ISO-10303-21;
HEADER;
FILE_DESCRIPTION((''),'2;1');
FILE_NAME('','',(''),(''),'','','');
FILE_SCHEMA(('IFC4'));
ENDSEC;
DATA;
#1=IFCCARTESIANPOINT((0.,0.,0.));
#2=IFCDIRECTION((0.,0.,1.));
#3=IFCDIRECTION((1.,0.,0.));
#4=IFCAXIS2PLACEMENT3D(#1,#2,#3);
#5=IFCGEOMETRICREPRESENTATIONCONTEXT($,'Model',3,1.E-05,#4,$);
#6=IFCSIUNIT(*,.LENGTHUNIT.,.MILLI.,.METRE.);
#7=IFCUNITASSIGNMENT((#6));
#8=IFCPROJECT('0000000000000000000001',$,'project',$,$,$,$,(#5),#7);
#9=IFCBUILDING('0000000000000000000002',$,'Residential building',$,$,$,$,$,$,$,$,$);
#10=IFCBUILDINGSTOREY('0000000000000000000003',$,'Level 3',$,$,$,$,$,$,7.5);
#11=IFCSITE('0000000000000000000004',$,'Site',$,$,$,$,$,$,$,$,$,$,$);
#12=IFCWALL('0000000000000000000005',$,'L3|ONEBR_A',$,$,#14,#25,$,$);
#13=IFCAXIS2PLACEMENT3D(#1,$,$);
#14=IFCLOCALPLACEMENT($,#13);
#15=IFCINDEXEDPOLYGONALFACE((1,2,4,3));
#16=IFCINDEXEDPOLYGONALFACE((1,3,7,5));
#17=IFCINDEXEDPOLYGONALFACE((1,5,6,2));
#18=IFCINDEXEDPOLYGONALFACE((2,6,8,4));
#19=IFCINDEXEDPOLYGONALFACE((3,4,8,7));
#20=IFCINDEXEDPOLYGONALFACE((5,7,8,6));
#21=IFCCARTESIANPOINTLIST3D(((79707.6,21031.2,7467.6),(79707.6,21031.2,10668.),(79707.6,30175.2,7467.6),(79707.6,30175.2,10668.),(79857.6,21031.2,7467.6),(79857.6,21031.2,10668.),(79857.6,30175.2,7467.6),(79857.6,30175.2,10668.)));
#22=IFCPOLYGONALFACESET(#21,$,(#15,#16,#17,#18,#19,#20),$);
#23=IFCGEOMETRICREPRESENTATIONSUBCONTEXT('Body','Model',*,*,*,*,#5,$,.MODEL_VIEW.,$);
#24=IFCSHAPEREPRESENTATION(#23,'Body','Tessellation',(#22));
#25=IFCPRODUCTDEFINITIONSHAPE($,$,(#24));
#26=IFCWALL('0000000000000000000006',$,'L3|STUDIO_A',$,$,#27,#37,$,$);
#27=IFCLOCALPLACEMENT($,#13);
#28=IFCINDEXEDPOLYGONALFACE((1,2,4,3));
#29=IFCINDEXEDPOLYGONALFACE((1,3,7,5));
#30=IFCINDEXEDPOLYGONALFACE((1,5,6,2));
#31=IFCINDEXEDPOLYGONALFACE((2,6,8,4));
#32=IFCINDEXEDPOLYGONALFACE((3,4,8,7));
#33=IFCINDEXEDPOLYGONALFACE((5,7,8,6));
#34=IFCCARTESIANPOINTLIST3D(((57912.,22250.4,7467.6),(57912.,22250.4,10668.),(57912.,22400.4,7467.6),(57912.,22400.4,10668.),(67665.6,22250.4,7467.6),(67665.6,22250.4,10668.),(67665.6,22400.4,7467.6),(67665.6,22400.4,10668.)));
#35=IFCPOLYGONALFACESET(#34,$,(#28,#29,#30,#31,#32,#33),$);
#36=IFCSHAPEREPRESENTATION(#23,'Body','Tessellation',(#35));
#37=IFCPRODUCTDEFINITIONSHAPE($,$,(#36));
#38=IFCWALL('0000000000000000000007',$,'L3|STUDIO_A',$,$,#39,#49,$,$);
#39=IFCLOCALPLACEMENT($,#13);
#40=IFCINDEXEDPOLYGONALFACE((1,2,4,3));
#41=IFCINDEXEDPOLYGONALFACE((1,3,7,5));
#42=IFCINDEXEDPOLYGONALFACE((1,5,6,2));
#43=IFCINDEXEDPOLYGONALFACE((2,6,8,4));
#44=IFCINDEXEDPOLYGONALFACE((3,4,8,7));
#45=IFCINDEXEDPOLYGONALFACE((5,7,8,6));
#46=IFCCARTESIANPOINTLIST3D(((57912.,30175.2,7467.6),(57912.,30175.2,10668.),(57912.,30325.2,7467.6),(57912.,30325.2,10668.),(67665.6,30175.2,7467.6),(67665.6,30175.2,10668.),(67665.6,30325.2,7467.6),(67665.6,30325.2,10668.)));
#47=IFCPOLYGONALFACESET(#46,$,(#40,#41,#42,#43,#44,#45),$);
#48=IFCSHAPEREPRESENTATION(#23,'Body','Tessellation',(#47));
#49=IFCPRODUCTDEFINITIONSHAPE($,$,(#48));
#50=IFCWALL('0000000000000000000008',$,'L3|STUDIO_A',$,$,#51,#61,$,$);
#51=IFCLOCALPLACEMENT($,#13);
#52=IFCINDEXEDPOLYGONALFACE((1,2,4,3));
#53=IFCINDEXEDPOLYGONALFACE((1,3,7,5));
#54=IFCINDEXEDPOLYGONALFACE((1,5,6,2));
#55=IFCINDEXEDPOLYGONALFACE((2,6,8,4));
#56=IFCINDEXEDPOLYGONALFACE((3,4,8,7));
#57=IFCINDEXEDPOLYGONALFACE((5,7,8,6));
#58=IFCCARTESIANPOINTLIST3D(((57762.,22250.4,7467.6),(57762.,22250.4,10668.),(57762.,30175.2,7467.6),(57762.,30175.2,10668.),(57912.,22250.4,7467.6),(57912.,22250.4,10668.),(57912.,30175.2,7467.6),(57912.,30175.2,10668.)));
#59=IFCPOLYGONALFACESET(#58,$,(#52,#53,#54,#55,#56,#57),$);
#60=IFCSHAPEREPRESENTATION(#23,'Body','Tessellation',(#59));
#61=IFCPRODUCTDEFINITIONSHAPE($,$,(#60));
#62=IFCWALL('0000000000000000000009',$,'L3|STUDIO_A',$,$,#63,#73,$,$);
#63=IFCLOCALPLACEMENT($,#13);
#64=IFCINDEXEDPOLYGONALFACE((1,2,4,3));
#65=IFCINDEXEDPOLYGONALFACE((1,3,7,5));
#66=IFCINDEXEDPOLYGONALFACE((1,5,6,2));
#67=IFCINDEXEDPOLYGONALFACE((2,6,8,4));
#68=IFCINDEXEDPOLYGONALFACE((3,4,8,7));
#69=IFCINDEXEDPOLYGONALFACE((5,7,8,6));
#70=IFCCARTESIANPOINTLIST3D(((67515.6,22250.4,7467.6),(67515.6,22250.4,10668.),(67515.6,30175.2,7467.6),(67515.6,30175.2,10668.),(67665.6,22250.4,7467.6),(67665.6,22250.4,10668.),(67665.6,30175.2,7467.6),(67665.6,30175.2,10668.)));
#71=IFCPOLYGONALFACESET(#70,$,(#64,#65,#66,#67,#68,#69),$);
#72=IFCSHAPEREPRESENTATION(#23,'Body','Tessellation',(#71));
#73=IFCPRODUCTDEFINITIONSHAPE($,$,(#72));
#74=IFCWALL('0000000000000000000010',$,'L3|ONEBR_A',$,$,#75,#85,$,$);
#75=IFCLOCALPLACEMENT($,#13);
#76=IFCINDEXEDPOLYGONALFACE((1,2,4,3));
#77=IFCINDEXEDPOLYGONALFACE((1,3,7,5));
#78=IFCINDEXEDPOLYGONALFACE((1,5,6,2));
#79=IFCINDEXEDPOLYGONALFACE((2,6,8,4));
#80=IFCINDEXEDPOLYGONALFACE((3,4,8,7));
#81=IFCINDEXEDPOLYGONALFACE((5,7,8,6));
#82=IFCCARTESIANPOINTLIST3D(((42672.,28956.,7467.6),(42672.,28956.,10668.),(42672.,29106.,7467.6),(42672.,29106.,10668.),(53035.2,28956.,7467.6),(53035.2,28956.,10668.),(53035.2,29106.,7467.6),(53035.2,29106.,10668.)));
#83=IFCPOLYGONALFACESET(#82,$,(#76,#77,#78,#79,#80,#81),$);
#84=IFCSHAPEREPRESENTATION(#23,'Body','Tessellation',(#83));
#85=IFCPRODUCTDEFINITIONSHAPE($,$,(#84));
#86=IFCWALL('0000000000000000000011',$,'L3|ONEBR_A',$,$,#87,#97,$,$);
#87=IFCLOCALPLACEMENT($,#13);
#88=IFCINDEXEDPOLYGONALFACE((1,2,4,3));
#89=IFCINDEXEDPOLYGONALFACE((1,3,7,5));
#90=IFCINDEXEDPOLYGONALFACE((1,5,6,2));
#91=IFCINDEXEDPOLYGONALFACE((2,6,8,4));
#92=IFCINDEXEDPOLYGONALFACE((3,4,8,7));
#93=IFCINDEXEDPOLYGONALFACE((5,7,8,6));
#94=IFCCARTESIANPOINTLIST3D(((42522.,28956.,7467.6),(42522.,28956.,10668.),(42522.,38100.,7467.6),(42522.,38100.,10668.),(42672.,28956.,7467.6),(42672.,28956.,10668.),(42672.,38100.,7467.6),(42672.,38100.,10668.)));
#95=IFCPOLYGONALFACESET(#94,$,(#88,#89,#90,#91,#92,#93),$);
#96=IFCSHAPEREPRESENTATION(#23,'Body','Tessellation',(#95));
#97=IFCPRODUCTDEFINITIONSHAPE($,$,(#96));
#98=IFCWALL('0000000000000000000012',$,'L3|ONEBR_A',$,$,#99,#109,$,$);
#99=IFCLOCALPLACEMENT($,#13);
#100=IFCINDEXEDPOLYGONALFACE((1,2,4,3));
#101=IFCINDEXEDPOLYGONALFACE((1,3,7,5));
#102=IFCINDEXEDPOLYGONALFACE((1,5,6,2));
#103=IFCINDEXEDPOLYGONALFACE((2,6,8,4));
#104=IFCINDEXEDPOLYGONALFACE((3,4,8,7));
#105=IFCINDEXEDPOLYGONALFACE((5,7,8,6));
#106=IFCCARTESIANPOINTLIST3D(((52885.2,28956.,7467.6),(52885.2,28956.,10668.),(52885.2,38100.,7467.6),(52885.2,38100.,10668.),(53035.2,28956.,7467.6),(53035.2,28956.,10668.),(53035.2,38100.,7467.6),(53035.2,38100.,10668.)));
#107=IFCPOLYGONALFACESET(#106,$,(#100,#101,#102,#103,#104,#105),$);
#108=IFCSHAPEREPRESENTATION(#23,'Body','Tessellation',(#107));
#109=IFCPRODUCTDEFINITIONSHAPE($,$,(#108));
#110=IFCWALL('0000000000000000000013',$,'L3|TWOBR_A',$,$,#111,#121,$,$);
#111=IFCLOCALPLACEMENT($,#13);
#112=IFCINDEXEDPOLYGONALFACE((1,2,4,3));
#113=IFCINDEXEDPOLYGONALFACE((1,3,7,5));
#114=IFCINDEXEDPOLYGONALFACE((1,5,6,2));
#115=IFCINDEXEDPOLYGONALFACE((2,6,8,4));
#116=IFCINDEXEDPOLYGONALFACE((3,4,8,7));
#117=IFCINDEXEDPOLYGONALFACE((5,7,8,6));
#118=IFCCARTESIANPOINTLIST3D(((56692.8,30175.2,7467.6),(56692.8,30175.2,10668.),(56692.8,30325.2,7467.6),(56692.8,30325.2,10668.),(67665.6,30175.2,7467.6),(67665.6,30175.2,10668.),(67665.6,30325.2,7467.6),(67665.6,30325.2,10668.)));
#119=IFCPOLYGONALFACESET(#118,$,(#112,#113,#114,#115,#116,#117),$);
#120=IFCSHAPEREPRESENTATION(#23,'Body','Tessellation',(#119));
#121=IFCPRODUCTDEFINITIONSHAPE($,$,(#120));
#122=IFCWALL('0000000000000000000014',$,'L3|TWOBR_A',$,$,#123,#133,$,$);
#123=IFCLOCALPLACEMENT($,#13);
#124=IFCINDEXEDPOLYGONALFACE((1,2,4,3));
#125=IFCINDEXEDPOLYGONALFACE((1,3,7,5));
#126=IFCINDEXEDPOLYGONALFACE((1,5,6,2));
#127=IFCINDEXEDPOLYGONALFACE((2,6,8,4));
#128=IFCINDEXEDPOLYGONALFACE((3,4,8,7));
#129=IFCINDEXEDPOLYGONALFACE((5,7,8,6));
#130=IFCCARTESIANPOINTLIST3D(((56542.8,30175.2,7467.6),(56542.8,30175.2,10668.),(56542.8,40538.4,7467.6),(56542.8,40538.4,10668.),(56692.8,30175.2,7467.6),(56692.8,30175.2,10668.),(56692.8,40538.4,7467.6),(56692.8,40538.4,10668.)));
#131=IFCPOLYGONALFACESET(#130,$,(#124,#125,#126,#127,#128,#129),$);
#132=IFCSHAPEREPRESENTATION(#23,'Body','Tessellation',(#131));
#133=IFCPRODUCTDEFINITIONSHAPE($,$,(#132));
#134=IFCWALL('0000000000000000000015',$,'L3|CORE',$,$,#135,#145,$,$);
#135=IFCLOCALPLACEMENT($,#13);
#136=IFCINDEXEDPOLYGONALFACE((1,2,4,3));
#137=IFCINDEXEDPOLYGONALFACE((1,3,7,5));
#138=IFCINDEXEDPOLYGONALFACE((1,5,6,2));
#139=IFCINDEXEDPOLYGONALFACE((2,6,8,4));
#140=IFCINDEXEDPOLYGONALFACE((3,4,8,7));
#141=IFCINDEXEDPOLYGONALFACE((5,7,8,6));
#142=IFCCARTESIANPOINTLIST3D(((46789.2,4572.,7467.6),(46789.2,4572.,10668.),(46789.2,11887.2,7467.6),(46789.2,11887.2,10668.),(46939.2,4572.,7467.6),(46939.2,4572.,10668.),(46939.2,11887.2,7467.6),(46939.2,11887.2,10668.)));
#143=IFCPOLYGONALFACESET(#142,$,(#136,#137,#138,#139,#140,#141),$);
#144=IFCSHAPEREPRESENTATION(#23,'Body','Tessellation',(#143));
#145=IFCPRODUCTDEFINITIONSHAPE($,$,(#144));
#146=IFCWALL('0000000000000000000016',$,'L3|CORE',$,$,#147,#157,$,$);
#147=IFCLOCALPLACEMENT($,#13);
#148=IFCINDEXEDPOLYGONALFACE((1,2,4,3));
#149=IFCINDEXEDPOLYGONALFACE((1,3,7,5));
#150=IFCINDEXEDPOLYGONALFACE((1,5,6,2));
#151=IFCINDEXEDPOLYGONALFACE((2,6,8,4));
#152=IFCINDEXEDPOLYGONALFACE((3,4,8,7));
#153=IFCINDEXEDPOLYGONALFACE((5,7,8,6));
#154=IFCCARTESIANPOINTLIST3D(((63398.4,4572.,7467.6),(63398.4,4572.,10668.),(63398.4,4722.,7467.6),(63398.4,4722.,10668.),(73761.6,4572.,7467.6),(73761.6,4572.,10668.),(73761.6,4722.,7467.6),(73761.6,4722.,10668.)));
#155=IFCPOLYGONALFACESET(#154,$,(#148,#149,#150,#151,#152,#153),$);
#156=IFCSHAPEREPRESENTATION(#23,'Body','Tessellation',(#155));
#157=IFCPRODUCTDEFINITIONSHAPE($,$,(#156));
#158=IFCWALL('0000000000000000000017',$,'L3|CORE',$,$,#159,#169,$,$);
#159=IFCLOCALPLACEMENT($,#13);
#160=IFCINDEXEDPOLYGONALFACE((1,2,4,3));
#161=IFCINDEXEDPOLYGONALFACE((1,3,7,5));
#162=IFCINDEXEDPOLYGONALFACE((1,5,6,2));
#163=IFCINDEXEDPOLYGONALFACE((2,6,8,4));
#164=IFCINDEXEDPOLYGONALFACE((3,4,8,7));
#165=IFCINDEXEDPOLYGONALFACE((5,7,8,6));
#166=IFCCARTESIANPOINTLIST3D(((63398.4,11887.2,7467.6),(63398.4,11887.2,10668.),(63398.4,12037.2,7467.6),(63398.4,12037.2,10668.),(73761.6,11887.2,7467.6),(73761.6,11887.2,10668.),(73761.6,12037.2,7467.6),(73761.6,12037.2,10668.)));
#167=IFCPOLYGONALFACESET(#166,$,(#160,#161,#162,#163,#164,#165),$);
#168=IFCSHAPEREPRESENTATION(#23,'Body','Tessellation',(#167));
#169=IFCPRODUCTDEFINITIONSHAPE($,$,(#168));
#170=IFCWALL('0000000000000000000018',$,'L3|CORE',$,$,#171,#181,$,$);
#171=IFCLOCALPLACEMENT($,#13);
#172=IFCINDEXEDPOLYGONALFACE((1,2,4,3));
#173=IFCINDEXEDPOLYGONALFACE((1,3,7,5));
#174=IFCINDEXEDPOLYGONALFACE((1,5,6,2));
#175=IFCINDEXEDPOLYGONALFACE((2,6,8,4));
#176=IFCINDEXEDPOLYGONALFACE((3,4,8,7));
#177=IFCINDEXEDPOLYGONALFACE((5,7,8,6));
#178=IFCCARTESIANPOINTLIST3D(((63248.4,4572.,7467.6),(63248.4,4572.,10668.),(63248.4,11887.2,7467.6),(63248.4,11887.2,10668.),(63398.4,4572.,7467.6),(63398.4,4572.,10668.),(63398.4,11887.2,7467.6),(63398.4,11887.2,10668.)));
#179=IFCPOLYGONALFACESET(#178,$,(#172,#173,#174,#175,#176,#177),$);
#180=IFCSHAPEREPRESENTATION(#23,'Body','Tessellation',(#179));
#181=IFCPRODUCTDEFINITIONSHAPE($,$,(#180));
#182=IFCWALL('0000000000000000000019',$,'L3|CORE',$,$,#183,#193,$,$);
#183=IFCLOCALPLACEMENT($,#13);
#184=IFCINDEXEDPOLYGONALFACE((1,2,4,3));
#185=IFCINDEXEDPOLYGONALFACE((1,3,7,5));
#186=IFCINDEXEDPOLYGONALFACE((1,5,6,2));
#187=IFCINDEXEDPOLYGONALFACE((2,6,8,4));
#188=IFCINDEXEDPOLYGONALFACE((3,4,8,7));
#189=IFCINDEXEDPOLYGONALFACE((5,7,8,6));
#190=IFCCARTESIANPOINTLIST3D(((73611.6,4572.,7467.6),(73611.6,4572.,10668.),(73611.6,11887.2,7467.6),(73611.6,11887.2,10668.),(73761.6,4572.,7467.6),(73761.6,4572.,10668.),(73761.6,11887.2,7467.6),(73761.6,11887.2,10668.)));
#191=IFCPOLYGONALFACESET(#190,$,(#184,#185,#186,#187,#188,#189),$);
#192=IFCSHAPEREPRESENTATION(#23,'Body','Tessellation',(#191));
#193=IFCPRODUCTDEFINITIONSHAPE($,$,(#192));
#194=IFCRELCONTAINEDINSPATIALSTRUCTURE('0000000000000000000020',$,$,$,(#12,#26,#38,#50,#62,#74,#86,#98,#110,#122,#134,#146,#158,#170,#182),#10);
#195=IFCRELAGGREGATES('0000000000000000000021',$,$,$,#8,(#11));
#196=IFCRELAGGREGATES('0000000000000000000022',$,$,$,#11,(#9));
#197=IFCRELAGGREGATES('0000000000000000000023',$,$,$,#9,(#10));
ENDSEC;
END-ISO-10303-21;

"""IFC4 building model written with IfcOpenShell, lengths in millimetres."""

from ifc_helpers import new_model, si_unit, frame, origin_with_axes, place, context, subcontext, project, spatial, indexed_curve, outline, extrude, element, save


model = new_model("IFC4")

# Units and contexts
model_context = context("Model", 3, precision=1e-05, world=origin_with_axes())
body_context = subcontext(model_context, "Body", "Model", "MODEL_VIEW")
ifc_project = project(units=[si_unit("LENGTHUNIT", "METRE", prefix="MILLI")], contexts=[model_context])

# Site, building, storey
site = spatial("IfcSite", under=ifc_project, Name="Site")
building = spatial("IfcBuilding", under=site, Name="Residential building")
storey = spatial("IfcBuildingStorey", under=building, Name="Level 3", Elevation=7.5)

# Walls
for number, where, z_axis, x_axis, name in (
    (1, (79857.6, 21031.2, 7467.6), (0.0, 0.0, 1.0), (0.0, 1.0, 0.0), "L3|ONEBR_A"),
):
    element("IfcWall", number, at=place(None, frame(where, z_axis=z_axis, x_axis=x_axis)), inside=storey, Name=name, context=body_context, shape_type="SweptSolid", body=[
        extrude(outline(indexed_curve([(0.0, 0.0), (0.0, 150.0), (9144.0, 150.0), (9144.0, 0.0), (0.0, 0.0)], self_intersect=False)), origin_with_axes(), (0.0, 0.0, 1.0), 3200.4),
    ])
for number, where, z_axis, x_axis, name in (
    (2, (57912.0, 22250.4, 7467.6), (0.0, 0.0, 1.0), (1.0, 0.0, 0.0), "L3|STUDIO_A"),
    (3, (57912.0, 30175.2, 7467.6), (0.0, 0.0, 1.0), (1.0, 0.0, 0.0), "L3|STUDIO_A"),
):
    element("IfcWall", number, at=place(None, frame(where, z_axis=z_axis, x_axis=x_axis)), inside=storey, Name=name, context=body_context, shape_type="SweptSolid", body=[
        extrude(outline(indexed_curve([(0.0, 0.0), (0.0, 150.0), (9753.6, 150.0), (9753.6, 0.0), (0.0, 0.0)], self_intersect=False)), origin_with_axes(), (0.0, 0.0, 1.0), 3200.4),
    ])
for number, where, z_axis, x_axis, name in (
    (4, (57912.0, 22250.4, 7467.6), (0.0, 0.0, 1.0), (0.0, 1.0, 0.0), "L3|STUDIO_A"),
    (5, (67665.6, 22250.4, 7467.6), (0.0, 0.0, 1.0), (0.0, 1.0, 0.0), "L3|STUDIO_A"),
):
    element("IfcWall", number, at=place(None, frame(where, z_axis=z_axis, x_axis=x_axis)), inside=storey, Name=name, context=body_context, shape_type="SweptSolid", body=[
        extrude(outline(indexed_curve([(0.0, 0.0), (0.0, 150.0), (7924.8, 150.0), (7924.8, 0.0), (0.0, 0.0)], self_intersect=False)), origin_with_axes(), (0.0, 0.0, 1.0), 3200.4),
    ])
wall_1_placement = place(None, frame((42672.0, 28956.0, 7467.6), z_axis=(0.0, 0.0, 1.0), x_axis=(1.0, 0.0, 0.0)))
element("IfcWall", 6, at=wall_1_placement, inside=storey, Name="L3|ONEBR_A", context=body_context, shape_type="SweptSolid", body=[
    extrude(outline(indexed_curve([(0.0, 0.0), (0.0, 150.0), (10363.2, 150.0), (10363.2, 0.0), (0.0, 0.0)], self_intersect=False)), origin_with_axes(), (0.0, 0.0, 1.0), 3200.4),
])
for number, where, z_axis, x_axis, name in (
    (7, (42672.0, 28956.0, 7467.6), (0.0, 0.0, 1.0), (0.0, 1.0, 0.0), "L3|ONEBR_A"),
    (8, (53035.2, 28956.0, 7467.6), (0.0, 0.0, 1.0), (0.0, 1.0, 0.0), "L3|ONEBR_A"),
):
    element("IfcWall", number, at=place(None, frame(where, z_axis=z_axis, x_axis=x_axis)), inside=storey, Name=name, context=body_context, shape_type="SweptSolid", body=[
        extrude(outline(indexed_curve([(0.0, 0.0), (0.0, 150.0), (9144.0, 150.0), (9144.0, 0.0), (0.0, 0.0)], self_intersect=False)), origin_with_axes(), (0.0, 0.0, 1.0), 3200.4),
    ])
wall_2_placement = place(None, frame((56692.8, 30175.2, 7467.6), z_axis=(0.0, 0.0, 1.0), x_axis=(1.0, 0.0, 0.0)))
element("IfcWall", 9, at=wall_2_placement, inside=storey, Name="L3|TWOBR_A", context=body_context, shape_type="SweptSolid", body=[
    extrude(outline(indexed_curve([(0.0, 0.0), (0.0, 150.0), (10972.8, 150.0), (10972.8, 0.0), (0.0, 0.0)], self_intersect=False)), origin_with_axes(), (0.0, 0.0, 1.0), 3200.4),
])
wall_3_placement = place(None, frame((56692.8, 30175.2, 7467.6), z_axis=(0.0, 0.0, 1.0), x_axis=(0.0, 1.0, 0.0)))
element("IfcWall", 10, at=wall_3_placement, inside=storey, Name="L3|TWOBR_A", context=body_context, shape_type="SweptSolid", body=[
    extrude(outline(indexed_curve([(0.0, 0.0), (0.0, 150.0), (10363.2, 150.0), (10363.2, 0.0), (0.0, 0.0)], self_intersect=False)), origin_with_axes(), (0.0, 0.0, 1.0), 3200.4),
])
wall_4_placement = place(None, frame((46939.2, 4572.0, 7467.6), z_axis=(0.0, 0.0, 1.0), x_axis=(0.0, 1.0, 0.0)))
element("IfcWall", 11, at=wall_4_placement, inside=storey, Name="L3|CORE", context=body_context, shape_type="SweptSolid", body=[
    extrude(outline(indexed_curve([(0.0, 0.0), (0.0, 150.0), (7315.2, 150.0), (7315.2, 0.0), (0.0, 0.0)], self_intersect=False)), origin_with_axes(), (0.0, 0.0, 1.0), 3200.4),
])
for number, where, z_axis, x_axis, name in (
    (12, (63398.4, 4572.0, 7467.6), (0.0, 0.0, 1.0), (1.0, 0.0, 0.0), "L3|CORE"),
    (13, (63398.4, 11887.2, 7467.6), (0.0, 0.0, 1.0), (1.0, 0.0, 0.0), "L3|CORE"),
):
    element("IfcWall", number, at=place(None, frame(where, z_axis=z_axis, x_axis=x_axis)), inside=storey, Name=name, context=body_context, shape_type="SweptSolid", body=[
        extrude(outline(indexed_curve([(0.0, 0.0), (0.0, 150.0), (10363.2, 150.0), (10363.2, 0.0), (0.0, 0.0)], self_intersect=False)), origin_with_axes(), (0.0, 0.0, 1.0), 3200.4),
    ])
for number, where, z_axis, x_axis, name in (
    (14, (63398.4, 4572.0, 7467.6), (0.0, 0.0, 1.0), (0.0, 1.0, 0.0), "L3|CORE"),
    (15, (73761.6, 4572.0, 7467.6), (0.0, 0.0, 1.0), (0.0, 1.0, 0.0), "L3|CORE"),
):
    element("IfcWall", number, at=place(None, frame(where, z_axis=z_axis, x_axis=x_axis)), inside=storey, Name=name, context=body_context, shape_type="SweptSolid", body=[
        extrude(outline(indexed_curve([(0.0, 0.0), (0.0, 150.0), (7315.2, 150.0), (7315.2, 0.0), (0.0, 0.0)], self_intersect=False)), origin_with_axes(), (0.0, 0.0, 1.0), 3200.4),
    ])

save(model, "model.ifc")
